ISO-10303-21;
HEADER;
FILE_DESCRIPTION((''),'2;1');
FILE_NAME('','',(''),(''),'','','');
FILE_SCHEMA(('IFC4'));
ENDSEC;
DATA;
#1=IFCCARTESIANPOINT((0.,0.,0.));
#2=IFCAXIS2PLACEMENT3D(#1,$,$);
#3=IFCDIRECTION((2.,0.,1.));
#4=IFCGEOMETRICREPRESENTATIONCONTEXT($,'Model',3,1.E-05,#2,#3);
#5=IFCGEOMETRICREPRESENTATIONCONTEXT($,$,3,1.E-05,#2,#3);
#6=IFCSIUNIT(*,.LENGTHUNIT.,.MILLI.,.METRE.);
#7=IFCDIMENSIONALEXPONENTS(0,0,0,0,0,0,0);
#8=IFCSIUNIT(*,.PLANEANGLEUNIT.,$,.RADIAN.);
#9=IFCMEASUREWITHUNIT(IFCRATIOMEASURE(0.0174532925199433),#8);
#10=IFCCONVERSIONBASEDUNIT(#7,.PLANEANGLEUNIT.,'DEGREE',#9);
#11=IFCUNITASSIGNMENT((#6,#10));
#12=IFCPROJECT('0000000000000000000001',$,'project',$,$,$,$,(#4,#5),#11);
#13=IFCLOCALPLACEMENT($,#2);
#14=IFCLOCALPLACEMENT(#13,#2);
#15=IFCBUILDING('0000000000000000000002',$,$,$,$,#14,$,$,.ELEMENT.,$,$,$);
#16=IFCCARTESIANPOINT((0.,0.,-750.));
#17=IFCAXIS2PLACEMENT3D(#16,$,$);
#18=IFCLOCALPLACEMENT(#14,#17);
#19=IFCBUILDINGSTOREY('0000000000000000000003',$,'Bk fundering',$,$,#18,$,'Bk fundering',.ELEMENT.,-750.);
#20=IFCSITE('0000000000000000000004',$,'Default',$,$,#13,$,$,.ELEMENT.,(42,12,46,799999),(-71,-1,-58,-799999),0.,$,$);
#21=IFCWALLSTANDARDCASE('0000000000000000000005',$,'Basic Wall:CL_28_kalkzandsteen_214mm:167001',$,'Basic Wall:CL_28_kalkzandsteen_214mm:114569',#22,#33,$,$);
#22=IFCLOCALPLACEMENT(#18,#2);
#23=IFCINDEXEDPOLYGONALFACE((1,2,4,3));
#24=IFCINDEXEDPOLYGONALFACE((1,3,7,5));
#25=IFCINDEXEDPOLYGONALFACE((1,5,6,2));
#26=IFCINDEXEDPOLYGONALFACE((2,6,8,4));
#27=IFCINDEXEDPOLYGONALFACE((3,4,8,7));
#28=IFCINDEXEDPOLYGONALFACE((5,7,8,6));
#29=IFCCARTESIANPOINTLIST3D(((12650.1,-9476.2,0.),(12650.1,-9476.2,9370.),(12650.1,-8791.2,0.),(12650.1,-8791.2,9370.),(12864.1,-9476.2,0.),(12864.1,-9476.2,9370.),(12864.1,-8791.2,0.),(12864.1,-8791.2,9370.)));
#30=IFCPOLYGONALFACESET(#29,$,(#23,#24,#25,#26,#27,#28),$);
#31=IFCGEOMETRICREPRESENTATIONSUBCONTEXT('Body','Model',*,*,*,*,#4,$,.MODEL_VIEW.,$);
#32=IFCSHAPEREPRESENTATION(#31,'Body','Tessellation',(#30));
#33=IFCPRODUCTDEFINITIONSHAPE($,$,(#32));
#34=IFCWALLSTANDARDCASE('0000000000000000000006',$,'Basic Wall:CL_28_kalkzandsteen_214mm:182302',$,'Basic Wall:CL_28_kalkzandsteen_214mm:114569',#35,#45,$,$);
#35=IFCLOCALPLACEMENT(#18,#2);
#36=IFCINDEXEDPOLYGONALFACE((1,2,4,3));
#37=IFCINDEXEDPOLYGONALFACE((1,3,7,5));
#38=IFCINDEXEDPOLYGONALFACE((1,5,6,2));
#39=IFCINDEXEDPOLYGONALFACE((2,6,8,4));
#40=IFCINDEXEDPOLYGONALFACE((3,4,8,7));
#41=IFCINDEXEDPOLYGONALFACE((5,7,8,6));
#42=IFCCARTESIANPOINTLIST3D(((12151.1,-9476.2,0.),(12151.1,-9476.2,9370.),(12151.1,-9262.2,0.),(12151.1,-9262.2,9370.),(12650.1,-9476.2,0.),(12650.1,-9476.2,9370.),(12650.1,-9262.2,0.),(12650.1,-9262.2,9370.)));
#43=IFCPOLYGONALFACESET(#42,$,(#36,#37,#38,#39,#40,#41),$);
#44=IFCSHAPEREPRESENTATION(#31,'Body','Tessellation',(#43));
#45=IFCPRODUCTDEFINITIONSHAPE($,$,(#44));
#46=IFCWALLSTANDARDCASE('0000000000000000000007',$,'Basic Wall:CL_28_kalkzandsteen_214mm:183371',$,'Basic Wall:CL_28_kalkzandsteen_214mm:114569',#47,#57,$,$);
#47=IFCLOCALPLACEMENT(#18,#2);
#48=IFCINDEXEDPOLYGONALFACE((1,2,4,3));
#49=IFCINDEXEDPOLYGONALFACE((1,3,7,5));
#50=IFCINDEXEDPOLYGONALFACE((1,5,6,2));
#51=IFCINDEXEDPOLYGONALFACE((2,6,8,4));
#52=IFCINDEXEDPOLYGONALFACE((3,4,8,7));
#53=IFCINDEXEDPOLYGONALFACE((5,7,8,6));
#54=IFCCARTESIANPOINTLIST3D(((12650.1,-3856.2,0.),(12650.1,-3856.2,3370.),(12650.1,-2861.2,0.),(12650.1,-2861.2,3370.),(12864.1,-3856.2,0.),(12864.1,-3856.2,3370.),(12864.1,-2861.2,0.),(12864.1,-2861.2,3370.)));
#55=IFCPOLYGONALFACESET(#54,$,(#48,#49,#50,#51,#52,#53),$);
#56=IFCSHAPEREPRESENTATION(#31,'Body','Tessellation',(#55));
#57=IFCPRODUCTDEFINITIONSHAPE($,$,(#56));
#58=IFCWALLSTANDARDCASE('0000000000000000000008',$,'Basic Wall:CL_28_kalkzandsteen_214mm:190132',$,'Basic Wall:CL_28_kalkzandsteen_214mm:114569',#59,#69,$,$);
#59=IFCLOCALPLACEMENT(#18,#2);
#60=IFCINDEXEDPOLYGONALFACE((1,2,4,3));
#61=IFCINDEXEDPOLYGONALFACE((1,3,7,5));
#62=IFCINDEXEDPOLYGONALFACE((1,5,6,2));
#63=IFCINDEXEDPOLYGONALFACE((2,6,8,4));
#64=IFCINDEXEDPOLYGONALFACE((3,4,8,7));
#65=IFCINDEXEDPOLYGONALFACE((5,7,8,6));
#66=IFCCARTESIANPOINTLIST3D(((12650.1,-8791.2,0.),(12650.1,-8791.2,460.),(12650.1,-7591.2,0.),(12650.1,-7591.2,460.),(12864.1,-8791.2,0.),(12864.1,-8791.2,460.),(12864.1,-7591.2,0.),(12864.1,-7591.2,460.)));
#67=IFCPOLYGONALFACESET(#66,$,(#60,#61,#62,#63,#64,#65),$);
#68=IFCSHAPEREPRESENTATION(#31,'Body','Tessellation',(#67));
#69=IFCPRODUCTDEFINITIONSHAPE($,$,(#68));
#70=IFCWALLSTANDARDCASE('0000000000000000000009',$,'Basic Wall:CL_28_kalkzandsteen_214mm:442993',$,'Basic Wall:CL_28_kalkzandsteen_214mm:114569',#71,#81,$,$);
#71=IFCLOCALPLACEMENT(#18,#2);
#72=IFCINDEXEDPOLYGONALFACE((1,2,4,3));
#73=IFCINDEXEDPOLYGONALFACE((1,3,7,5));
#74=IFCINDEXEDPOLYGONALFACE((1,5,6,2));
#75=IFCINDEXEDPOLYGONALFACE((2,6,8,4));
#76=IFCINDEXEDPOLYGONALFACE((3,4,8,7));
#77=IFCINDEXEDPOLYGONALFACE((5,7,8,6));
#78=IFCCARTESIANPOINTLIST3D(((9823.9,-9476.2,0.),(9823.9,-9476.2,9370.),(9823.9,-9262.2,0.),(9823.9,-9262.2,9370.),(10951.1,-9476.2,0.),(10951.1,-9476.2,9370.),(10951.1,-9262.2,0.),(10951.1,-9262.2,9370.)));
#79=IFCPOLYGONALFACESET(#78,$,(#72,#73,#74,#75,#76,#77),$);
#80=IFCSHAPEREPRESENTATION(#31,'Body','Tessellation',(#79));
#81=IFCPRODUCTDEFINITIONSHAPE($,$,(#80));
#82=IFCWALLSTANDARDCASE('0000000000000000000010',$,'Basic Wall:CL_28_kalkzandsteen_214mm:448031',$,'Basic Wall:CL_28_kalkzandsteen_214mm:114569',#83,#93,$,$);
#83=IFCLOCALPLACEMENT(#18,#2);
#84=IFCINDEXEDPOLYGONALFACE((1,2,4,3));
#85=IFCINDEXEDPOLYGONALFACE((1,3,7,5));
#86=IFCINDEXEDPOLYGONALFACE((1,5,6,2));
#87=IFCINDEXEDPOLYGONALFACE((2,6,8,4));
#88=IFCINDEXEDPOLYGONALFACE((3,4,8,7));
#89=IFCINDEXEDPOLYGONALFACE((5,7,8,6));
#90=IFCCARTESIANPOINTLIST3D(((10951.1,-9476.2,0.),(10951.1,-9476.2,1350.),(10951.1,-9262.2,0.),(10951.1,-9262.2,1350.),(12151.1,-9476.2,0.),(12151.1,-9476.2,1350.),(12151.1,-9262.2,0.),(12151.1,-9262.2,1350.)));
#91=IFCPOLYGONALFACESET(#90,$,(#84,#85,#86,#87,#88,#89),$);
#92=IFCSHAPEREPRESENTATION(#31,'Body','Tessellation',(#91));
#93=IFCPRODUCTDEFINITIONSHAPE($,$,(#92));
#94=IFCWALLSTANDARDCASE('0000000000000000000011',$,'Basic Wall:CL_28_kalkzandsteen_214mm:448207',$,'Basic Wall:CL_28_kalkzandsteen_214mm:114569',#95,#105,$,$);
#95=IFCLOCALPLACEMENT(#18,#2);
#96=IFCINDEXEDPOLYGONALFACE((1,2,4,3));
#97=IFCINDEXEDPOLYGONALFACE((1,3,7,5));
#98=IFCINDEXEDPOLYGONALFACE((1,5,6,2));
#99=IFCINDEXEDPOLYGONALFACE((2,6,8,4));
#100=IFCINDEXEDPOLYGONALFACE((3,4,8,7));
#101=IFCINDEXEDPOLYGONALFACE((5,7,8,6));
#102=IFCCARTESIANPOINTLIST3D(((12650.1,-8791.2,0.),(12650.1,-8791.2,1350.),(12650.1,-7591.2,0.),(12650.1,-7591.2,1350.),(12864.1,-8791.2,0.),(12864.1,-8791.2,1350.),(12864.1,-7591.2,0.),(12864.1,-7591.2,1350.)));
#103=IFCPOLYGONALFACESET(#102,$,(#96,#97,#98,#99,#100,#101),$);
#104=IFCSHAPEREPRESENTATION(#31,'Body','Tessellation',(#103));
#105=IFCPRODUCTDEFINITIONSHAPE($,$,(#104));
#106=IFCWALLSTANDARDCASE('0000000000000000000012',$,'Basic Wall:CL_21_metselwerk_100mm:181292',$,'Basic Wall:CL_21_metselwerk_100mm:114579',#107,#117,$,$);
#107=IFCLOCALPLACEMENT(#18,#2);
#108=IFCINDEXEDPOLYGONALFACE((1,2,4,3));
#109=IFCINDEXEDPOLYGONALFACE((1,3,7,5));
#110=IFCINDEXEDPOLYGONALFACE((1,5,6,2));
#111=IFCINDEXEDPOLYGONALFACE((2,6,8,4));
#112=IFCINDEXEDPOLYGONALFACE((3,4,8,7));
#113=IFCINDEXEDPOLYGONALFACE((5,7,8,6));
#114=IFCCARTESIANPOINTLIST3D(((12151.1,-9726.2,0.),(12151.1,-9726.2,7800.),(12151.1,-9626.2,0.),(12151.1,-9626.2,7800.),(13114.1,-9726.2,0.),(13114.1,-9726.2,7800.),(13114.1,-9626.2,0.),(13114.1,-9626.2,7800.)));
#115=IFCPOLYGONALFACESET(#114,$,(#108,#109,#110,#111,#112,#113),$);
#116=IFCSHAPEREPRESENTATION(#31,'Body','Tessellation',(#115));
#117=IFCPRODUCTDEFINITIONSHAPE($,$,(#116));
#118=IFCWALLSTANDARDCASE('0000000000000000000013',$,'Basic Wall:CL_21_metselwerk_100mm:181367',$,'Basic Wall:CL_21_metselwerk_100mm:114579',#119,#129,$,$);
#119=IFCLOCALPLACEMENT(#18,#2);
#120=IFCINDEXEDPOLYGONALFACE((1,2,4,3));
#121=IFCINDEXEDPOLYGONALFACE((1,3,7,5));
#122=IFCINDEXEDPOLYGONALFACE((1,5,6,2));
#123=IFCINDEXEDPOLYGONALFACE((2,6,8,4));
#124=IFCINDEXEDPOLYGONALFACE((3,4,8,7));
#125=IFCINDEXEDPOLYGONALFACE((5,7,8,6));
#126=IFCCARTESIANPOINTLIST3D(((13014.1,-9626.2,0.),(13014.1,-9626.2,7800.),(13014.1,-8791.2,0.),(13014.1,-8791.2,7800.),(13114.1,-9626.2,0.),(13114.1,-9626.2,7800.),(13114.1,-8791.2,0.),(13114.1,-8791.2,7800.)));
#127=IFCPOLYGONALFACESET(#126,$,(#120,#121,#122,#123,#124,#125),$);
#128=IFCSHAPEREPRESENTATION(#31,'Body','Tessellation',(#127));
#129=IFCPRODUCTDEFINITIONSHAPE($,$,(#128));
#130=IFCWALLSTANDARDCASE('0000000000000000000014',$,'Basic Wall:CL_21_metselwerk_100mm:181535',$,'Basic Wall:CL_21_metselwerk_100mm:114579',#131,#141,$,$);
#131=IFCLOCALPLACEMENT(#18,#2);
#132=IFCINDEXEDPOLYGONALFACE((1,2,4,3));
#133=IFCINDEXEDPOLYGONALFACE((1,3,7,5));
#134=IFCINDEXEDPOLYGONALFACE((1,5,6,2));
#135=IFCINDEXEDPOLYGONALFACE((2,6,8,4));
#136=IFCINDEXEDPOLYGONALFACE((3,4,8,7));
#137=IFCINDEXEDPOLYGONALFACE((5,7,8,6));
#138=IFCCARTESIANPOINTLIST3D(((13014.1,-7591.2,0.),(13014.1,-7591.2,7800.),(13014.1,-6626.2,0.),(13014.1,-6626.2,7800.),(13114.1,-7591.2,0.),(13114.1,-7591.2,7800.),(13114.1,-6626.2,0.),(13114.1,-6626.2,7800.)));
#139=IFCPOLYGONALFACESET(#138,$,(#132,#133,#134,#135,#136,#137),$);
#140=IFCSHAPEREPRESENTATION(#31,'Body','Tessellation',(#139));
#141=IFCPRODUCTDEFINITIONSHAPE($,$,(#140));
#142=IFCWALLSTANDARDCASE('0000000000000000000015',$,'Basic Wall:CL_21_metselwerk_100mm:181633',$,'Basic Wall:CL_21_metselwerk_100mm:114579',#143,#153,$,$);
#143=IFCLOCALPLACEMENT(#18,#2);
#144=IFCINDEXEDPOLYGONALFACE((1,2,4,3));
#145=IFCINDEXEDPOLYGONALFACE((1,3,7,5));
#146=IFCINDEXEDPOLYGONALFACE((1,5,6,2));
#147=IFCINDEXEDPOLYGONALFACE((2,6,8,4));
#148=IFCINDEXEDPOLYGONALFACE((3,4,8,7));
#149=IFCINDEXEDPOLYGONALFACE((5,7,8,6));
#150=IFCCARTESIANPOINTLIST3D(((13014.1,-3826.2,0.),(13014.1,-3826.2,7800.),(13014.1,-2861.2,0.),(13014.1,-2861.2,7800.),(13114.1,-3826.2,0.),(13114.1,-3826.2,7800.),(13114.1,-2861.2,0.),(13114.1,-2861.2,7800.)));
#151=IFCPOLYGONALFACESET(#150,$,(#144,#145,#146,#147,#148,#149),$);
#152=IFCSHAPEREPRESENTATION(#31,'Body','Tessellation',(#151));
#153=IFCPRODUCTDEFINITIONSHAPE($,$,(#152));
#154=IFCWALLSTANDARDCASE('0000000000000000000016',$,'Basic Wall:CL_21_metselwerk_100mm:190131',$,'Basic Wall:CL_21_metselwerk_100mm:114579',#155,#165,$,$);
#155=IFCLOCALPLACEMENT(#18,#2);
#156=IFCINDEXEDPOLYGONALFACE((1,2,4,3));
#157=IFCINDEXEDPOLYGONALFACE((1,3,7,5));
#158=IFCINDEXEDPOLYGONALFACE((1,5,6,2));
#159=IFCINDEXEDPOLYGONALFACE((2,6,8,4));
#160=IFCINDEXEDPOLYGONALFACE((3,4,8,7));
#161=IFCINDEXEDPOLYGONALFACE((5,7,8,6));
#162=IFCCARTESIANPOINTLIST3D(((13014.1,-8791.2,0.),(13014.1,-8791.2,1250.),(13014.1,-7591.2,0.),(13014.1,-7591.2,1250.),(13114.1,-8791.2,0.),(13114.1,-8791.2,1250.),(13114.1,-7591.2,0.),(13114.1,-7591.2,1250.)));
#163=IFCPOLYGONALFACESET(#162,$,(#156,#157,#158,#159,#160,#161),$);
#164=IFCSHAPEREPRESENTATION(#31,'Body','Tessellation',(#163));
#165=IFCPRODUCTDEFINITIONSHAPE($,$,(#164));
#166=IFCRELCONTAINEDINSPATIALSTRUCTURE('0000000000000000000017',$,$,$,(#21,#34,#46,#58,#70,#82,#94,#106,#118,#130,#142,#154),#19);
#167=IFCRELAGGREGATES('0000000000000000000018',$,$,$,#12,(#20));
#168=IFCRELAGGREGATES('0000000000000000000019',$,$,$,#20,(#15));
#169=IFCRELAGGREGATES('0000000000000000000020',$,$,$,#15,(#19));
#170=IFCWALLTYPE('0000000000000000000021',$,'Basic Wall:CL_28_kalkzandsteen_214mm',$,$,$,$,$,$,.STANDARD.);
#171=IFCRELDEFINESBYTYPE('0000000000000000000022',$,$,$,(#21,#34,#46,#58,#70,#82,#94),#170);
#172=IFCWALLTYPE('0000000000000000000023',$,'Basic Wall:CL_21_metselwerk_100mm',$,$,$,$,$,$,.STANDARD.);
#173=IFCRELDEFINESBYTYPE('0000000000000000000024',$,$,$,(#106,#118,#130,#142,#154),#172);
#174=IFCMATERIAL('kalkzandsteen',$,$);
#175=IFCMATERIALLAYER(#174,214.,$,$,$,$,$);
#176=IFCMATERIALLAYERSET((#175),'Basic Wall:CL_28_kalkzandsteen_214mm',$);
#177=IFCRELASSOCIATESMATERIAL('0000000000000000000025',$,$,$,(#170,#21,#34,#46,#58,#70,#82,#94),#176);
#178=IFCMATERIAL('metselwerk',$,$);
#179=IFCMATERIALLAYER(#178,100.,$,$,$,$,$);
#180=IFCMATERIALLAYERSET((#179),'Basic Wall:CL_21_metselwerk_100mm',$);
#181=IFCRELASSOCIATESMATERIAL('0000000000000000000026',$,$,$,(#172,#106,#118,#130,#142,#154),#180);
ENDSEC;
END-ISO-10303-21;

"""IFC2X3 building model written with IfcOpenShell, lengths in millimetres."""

from ifc_helpers import new_model, entity, si_unit, converted_unit, direction, frame, frame_2d, origin, place, context, subcontext, project, spatial, polyline, rectangle, extrude, clip, bounded_halfspace, material, layer, layer_set, layer_usage, type_object, element, save


model = new_model("IFC2X3")

# Units and contexts
model_context = context("Model", 3, precision=1e-05, world=origin(), true_north=direction((2.0, 0.0, 1.0)))
context_of_model = context(None, 3, precision=1e-05, world=origin(), true_north=direction((2.0, 0.0, 1.0)))
body_context = subcontext(model_context, "Body", "Model", "MODEL_VIEW")
ifc_project = project(units=[si_unit("LENGTHUNIT", "METRE", prefix="MILLI"), converted_unit("PLANEANGLEUNIT", "DEGREE", entity("IfcRatioMeasure", 0.0174532925199433), si_unit("PLANEANGLEUNIT", "RADIAN"), dimensions=[0, 0, 0, 0, 0, 0, 0])], contexts=[model_context, context_of_model])

# Site, building, storey
site_placement = place(None, origin())
site = spatial("IfcSite", under=ifc_project, at=site_placement, Name="Default", CompositionType="ELEMENT", RefLatitude=(42, 12, 46, 799999), RefLongitude=(-71, -1, -58, -799999), RefElevation=0.0)
building_placement = place(site_placement, origin())
building = spatial("IfcBuilding", under=site, at=building_placement, CompositionType="ELEMENT")
storey_placement = place(building_placement, frame((0.0, 0.0, -750.0)))
storey = spatial("IfcBuildingStorey", under=building, at=storey_placement, Name="Bk fundering", LongName="Bk fundering", CompositionType="ELEMENT", Elevation=-750.0)

# Walls
ifc_material_1 = material(Name="kalkzandsteen")
ifc_layer_1 = layer(ifc_material_1, 214.0)
ifc_layer_set_1 = layer_set([ifc_layer_1], Name="Basic Wall:CL_28_kalkzandsteen_214mm")
ifc_layer_usage_1 = layer_usage(ifc_layer_set_1, "AXIS2", "NEGATIVE", 107.0)
wall_type_1 = type_object("IfcWallType", Name="Basic Wall:CL_28_kalkzandsteen_214mm", PredefinedType="STANDARD", material=ifc_layer_set_1)
wall_1_placement = place(storey_placement, frame((12757.1, -9476.2, 0.0), z_axis=(0.0, 0.0, 1.0), x_axis=(0.0, 1.0, 0.0)))
element("IfcWallStandardCase", 1, at=wall_1_placement, inside=storey, type_object=wall_type_1, material=ifc_layer_usage_1, Name="Basic Wall:CL_28_kalkzandsteen_214mm:167001", ObjectType="Basic Wall:CL_28_kalkzandsteen_214mm:114569", context=body_context, shape_type="Clipping", body=[
    clip(extrude(rectangle(XDim=685.0, YDim=214.0, at=frame_2d((342.5, 0.0), x_axis=(-1.0, 0.0))), origin(), (0.0, 0.0, 1.0), 9370.0), bounded_halfspace(frame((0.0, -107.0, 9370.0), z_axis=(0.0, 0.0, -1.0), x_axis=(0.0, -1.0, 0.0)), True, frame((0.0, -107.0, 9370.0)), polyline([(0.0, 0.0), (685.0, 0.0), (685.0, 214.0), (214.0, 214.0), (0.0, 214.0), (0.0, 0.0)]))),
])
ifc_layer_usage_2 = layer_usage(ifc_layer_set_1, "AXIS2", "NEGATIVE", 107.0)
wall_2_placement = place(storey_placement, frame((12151.1, -9369.2, 0.0)))
element("IfcWallStandardCase", 2, at=wall_2_placement, inside=storey, type_object=wall_type_1, material=ifc_layer_usage_2, Name="Basic Wall:CL_28_kalkzandsteen_214mm:182302", ObjectType="Basic Wall:CL_28_kalkzandsteen_214mm:114569", context=body_context, shape_type="Clipping", body=[
    clip(extrude(rectangle(XDim=499.0, YDim=214.0, at=frame_2d((249.5, 0.0), x_axis=(-1.0, 0.0))), origin(), (0.0, 0.0, 1.0), 9370.0), bounded_halfspace(frame((0.0, -107.0, 9370.0), z_axis=(0.0, 0.0, -1.0), x_axis=(1.0, 0.0, 0.0)), True, frame((0.0, -107.0, 9370.0)), polyline([(0.0, 0.0), (499.0, 0.0), (499.0, 214.0), (0.0, 214.0), (0.0, 0.0)]))),
])
ifc_layer_usage_3 = layer_usage(ifc_layer_set_1, "AXIS2", "NEGATIVE", 107.0)
wall_3_placement = place(storey_placement, frame((12757.1, -3856.2, 0.0), z_axis=(0.0, 0.0, 1.0), x_axis=(0.0, 1.0, 0.0)))
element("IfcWallStandardCase", 3, at=wall_3_placement, inside=storey, type_object=wall_type_1, material=ifc_layer_usage_3, Name="Basic Wall:CL_28_kalkzandsteen_214mm:183371", ObjectType="Basic Wall:CL_28_kalkzandsteen_214mm:114569", context=body_context, shape_type="Clipping", body=[
    clip(extrude(rectangle(XDim=995.0, YDim=214.0, at=frame_2d((497.5, 0.0), x_axis=(-1.0, 0.0))), origin(), (0.0, 0.0, 1.0), 3370.0), bounded_halfspace(frame((0.0, -107.0, 3370.0), z_axis=(0.0, 0.0, -1.0), x_axis=(0.0, -1.0, 0.0)), True, frame((0.0, -107.0, 3370.0)), polyline([(0.0, 0.0), (995.0, 0.0), (995.0, 214.0), (0.0, 214.0), (0.0, 0.0)]))),
])
ifc_layer_usage_4 = layer_usage(ifc_layer_set_1, "AXIS2", "NEGATIVE", 107.0)
wall_4_placement = place(storey_placement, frame((12757.1, -8791.2, 0.0), z_axis=(0.0, 0.0, 1.0), x_axis=(0.0, 1.0, 0.0)))
element("IfcWallStandardCase", 4, at=wall_4_placement, inside=storey, type_object=wall_type_1, material=ifc_layer_usage_4, Name="Basic Wall:CL_28_kalkzandsteen_214mm:190132", ObjectType="Basic Wall:CL_28_kalkzandsteen_214mm:114569", context=body_context, shape_type="Clipping", body=[
    clip(extrude(rectangle(XDim=1200.0, YDim=214.0, at=frame_2d((600.0, 0.0), x_axis=(-1.0, 0.0))), origin(), (0.0, 0.0, 1.0), 460.0), bounded_halfspace(frame((0.0, -107.0, 460.0), z_axis=(0.0, 0.0, -1.0), x_axis=(-1.0, 0.0, 0.0)), True, frame((0.0, -107.0, 460.0)), polyline([(0.0, 0.0), (1200.0, 0.0), (1200.0, 214.0), (0.0, 214.0), (0.0, 0.0)]))),
])
ifc_layer_usage_5 = layer_usage(ifc_layer_set_1, "AXIS2", "POSITIVE", -107.0)
wall_5_placement = place(storey_placement, frame((10951.1, -9369.2, 0.0), z_axis=(0.0, 0.0, 1.0), x_axis=(-1.0, 0.0, 0.0)))
element("IfcWallStandardCase", 5, at=wall_5_placement, inside=storey, type_object=wall_type_1, material=ifc_layer_usage_5, Name="Basic Wall:CL_28_kalkzandsteen_214mm:442993", ObjectType="Basic Wall:CL_28_kalkzandsteen_214mm:114569", context=body_context, shape_type="Clipping", body=[
    clip(extrude(rectangle(XDim=1127.2, YDim=214.0, at=frame_2d((563.6, 0.0), x_axis=(-1.0, 0.0))), origin(), (0.0, 0.0, 1.0), 9370.0), bounded_halfspace(frame((0.0, -107.0, 9370.0), z_axis=(0.0, 0.0, -1.0), x_axis=(-1.0, 0.0, 0.0)), True, frame((0.0, -107.0, 9370.0)), polyline([(0.0, 0.0), (1127.2, 0.0), (1127.2, 214.0), (0.0, 214.0), (0.0, 0.0)]))),
])
ifc_layer_usage_6 = layer_usage(ifc_layer_set_1, "AXIS2", "NEGATIVE", 107.0)
wall_6_placement = place(storey_placement, frame((10951.1, -9369.2, 0.0)))
element("IfcWallStandardCase", 6, at=wall_6_placement, inside=storey, type_object=wall_type_1, material=ifc_layer_usage_6, Name="Basic Wall:CL_28_kalkzandsteen_214mm:448031", ObjectType="Basic Wall:CL_28_kalkzandsteen_214mm:114569", context=body_context, shape_type="SweptSolid", body=[
    extrude(rectangle(XDim=1200.0, YDim=214.0, at=frame_2d((600.0, 0.0), x_axis=(-1.0, 0.0))), origin(), (0.0, 0.0, 1.0), 1350.0),
])
ifc_layer_usage_7 = layer_usage(ifc_layer_set_1, "AXIS2", "NEGATIVE", 107.0)
wall_7_placement = place(storey_placement, frame((12757.1, -8791.2, 0.0), z_axis=(0.0, 0.0, 1.0), x_axis=(0.0, 1.0, 0.0)))
element("IfcWallStandardCase", 7, at=wall_7_placement, inside=storey, type_object=wall_type_1, material=ifc_layer_usage_7, Name="Basic Wall:CL_28_kalkzandsteen_214mm:448207", ObjectType="Basic Wall:CL_28_kalkzandsteen_214mm:114569", context=body_context, shape_type="SweptSolid", body=[
    extrude(rectangle(XDim=1200.0, YDim=214.0, at=frame_2d((600.0, 0.0), x_axis=(-1.0, 0.0))), origin(), (0.0, 0.0, 1.0), 1350.0),
])
ifc_material_2 = material(Name="metselwerk")
ifc_layer_2 = layer(ifc_material_2, 100.0)
ifc_layer_set_2 = layer_set([ifc_layer_2], Name="Basic Wall:CL_21_metselwerk_100mm")
ifc_layer_usage_8 = layer_usage(ifc_layer_set_2, "AXIS2", "NEGATIVE", 50.0)
wall_type_2 = type_object("IfcWallType", Name="Basic Wall:CL_21_metselwerk_100mm", PredefinedType="STANDARD", material=ifc_layer_set_2)
wall_8_placement = place(storey_placement, frame((12151.1, -9676.2, 0.0)))
element("IfcWallStandardCase", 8, at=wall_8_placement, inside=storey, type_object=wall_type_2, material=ifc_layer_usage_8, Name="Basic Wall:CL_21_metselwerk_100mm:181292", ObjectType="Basic Wall:CL_21_metselwerk_100mm:114579", context=body_context, shape_type="SweptSolid", body=[
    extrude(rectangle(XDim=963.0, YDim=100.0, at=frame_2d((481.5, 0.0), x_axis=(-1.0, 0.0))), origin(), (0.0, 0.0, 1.0), 7800.0),
])
ifc_layer_usage_9 = layer_usage(ifc_layer_set_2, "AXIS2", "NEGATIVE", 50.0)
wall_9_placement = place(storey_placement, frame((13064.1, -9626.2, 0.0), z_axis=(0.0, 0.0, 1.0), x_axis=(0.0, 1.0, 0.0)))
element("IfcWallStandardCase", 9, at=wall_9_placement, inside=storey, type_object=wall_type_2, material=ifc_layer_usage_9, Name="Basic Wall:CL_21_metselwerk_100mm:181367", ObjectType="Basic Wall:CL_21_metselwerk_100mm:114579", context=body_context, shape_type="SweptSolid", body=[
    extrude(rectangle(XDim=835.0, YDim=100.0, at=frame_2d((417.5, 0.0), x_axis=(-1.0, 0.0))), origin(), (0.0, 0.0, 1.0), 7800.0),
])
ifc_layer_usage_10 = layer_usage(ifc_layer_set_2, "AXIS2", "NEGATIVE", 50.0)
wall_10_placement = place(storey_placement, frame((13064.1, -7591.2, 0.0), z_axis=(0.0, 0.0, 1.0), x_axis=(0.0, 1.0, 0.0)))
element("IfcWallStandardCase", 10, at=wall_10_placement, inside=storey, type_object=wall_type_2, material=ifc_layer_usage_10, Name="Basic Wall:CL_21_metselwerk_100mm:181535", ObjectType="Basic Wall:CL_21_metselwerk_100mm:114579", context=body_context, shape_type="SweptSolid", body=[
    extrude(rectangle(XDim=965.0, YDim=100.0, at=frame_2d((482.5, 0.0), x_axis=(-1.0, 0.0))), origin(), (0.0, 0.0, 1.0), 7800.0),
])
ifc_layer_usage_11 = layer_usage(ifc_layer_set_2, "AXIS2", "NEGATIVE", 50.0)
wall_11_placement = place(storey_placement, frame((13064.1, -3826.2, 0.0), z_axis=(0.0, 0.0, 1.0), x_axis=(0.0, 1.0, 0.0)))
element("IfcWallStandardCase", 11, at=wall_11_placement, inside=storey, type_object=wall_type_2, material=ifc_layer_usage_11, Name="Basic Wall:CL_21_metselwerk_100mm:181633", ObjectType="Basic Wall:CL_21_metselwerk_100mm:114579", context=body_context, shape_type="SweptSolid", body=[
    extrude(rectangle(XDim=965.0, YDim=100.0, at=frame_2d((482.5, 0.0), x_axis=(-1.0, 0.0))), origin(), (0.0, 0.0, 1.0), 7800.0),
])
ifc_layer_usage_12 = layer_usage(ifc_layer_set_2, "AXIS2", "NEGATIVE", 50.0)
wall_12_placement = place(storey_placement, frame((13064.1, -8791.2, 0.0), z_axis=(0.0, 0.0, 1.0), x_axis=(0.0, 1.0, 0.0)))
element("IfcWallStandardCase", 12, at=wall_12_placement, inside=storey, type_object=wall_type_2, material=ifc_layer_usage_12, Name="Basic Wall:CL_21_metselwerk_100mm:190131", ObjectType="Basic Wall:CL_21_metselwerk_100mm:114579", context=body_context, shape_type="SweptSolid", body=[
    extrude(rectangle(XDim=1200.0, YDim=100.0, at=frame_2d((600.0, 0.0), x_axis=(-1.0, 0.0))), origin(), (0.0, 0.0, 1.0), 1250.0),
])

save(model, "model.ifc")
